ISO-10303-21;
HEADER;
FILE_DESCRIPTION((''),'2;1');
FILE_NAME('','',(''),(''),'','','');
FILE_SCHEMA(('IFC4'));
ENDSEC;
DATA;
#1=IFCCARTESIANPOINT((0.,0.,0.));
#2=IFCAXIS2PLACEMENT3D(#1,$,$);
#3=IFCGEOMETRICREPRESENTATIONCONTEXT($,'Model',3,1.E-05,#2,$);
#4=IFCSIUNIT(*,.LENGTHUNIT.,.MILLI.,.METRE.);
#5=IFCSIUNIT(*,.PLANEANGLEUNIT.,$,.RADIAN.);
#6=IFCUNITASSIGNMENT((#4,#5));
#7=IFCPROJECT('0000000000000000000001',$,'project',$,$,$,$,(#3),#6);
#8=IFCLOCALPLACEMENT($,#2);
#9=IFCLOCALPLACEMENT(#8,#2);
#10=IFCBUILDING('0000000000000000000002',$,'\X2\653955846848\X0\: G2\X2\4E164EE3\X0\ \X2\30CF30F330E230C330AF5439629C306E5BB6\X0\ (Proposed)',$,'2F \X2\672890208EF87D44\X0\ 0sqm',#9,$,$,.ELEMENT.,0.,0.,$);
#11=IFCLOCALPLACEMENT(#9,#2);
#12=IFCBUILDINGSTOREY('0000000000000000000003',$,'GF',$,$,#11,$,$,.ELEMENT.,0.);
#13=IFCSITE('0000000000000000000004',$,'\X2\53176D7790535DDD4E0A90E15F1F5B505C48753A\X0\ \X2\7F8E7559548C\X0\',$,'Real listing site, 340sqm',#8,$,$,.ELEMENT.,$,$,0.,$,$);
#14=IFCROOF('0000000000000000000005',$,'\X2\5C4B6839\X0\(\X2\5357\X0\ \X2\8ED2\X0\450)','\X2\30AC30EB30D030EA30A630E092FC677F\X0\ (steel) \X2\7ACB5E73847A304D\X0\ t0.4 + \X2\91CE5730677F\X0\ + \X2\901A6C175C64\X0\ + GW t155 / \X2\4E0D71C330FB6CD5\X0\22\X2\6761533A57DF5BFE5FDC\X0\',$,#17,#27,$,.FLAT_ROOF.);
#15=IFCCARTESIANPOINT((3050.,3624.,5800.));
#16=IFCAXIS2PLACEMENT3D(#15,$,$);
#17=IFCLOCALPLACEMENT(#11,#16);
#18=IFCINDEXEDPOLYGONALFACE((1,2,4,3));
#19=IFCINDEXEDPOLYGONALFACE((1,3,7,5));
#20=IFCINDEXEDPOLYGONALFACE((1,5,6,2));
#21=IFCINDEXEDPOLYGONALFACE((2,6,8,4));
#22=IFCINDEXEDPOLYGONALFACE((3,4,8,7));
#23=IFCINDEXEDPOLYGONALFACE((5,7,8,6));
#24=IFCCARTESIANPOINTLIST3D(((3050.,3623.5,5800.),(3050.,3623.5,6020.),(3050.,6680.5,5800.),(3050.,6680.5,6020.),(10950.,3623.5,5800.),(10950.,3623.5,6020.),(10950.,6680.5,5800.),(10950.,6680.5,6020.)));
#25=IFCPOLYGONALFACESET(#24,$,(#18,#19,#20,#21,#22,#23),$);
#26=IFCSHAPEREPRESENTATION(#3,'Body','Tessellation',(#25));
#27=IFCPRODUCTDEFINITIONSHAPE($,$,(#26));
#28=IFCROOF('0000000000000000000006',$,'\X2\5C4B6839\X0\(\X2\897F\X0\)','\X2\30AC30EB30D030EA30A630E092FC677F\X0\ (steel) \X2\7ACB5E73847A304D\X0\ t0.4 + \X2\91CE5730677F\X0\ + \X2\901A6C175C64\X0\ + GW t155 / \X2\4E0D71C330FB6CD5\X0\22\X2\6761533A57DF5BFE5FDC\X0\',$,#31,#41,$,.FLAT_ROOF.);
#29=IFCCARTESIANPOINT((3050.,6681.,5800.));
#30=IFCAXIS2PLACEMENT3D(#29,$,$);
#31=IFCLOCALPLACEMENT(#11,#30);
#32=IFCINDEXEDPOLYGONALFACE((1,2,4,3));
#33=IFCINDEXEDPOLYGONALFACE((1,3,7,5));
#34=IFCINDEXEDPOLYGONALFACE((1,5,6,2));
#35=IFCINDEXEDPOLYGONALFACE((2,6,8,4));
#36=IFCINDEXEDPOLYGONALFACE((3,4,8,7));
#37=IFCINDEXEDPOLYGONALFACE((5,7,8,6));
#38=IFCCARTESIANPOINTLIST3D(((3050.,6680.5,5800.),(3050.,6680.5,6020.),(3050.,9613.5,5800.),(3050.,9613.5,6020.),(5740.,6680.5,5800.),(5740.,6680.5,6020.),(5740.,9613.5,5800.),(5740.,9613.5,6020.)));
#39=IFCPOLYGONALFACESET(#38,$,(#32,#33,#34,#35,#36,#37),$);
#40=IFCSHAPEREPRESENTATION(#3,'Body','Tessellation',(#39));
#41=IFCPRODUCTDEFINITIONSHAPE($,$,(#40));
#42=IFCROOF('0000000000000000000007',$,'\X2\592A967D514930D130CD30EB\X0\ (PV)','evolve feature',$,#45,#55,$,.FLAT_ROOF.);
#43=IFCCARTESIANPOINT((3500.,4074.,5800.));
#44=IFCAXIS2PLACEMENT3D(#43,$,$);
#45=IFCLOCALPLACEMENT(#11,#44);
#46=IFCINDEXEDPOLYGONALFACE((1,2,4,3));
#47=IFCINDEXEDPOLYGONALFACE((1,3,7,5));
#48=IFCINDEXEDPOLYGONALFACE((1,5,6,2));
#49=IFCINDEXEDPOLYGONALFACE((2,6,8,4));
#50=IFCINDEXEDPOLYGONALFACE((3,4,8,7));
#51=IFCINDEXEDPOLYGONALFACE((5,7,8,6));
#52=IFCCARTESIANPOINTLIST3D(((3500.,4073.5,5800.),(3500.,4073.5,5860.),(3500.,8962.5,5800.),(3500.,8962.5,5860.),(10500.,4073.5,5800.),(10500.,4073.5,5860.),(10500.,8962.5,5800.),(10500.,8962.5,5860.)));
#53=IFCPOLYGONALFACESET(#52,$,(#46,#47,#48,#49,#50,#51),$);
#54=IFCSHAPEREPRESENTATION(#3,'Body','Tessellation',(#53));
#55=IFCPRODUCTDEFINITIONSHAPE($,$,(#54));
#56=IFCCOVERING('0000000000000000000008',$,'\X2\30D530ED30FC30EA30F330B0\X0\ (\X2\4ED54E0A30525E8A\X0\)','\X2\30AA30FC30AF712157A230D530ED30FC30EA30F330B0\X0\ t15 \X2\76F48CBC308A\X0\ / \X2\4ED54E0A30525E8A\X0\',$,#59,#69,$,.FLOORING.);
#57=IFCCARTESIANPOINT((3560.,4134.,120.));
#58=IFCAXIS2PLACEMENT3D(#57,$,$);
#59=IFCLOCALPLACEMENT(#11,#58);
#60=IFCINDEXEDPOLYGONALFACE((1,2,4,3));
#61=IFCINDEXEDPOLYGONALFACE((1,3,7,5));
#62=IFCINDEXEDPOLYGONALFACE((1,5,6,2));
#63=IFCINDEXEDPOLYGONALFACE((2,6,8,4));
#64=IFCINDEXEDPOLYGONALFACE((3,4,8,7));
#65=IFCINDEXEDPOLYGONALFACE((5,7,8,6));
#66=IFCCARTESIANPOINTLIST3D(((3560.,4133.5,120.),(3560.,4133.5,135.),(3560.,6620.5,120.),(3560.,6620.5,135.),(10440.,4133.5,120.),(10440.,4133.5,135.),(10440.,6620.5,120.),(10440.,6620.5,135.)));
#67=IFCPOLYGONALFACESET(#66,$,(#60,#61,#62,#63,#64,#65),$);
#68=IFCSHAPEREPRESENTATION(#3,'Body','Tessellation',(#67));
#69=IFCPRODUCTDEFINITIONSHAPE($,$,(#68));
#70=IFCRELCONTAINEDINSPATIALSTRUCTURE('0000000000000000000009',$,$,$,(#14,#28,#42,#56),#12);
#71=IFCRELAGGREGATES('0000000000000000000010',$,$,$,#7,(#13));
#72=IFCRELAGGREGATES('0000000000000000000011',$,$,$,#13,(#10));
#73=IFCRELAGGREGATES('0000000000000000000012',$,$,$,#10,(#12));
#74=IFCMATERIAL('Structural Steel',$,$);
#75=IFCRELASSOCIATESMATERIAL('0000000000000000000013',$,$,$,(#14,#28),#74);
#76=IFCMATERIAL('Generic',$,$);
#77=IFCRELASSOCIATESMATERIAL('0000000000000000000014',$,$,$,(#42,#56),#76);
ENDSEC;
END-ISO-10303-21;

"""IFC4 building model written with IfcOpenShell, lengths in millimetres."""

from ifc_helpers import new_model, si_unit, frame, frame_2d, origin, place, context, project, spatial, rectangle, extrude, material, element, save


model = new_model("IFC4")

# Units and contexts
model_context = context("Model", 3, precision=1e-05, world=origin())
ifc_project = project(units=[si_unit("LENGTHUNIT", "METRE", prefix="MILLI"), si_unit("PLANEANGLEUNIT", "RADIAN")], contexts=[model_context])

# Site, building, storey
site_placement = place(None, origin())
site = spatial("IfcSite", under=ifc_project, at=site_placement, Name="北海道川上郡弟子屈町 美留和", ObjectType="Real listing site, 340sqm", CompositionType="ELEMENT", RefElevation=0.0)
building_placement = place(site_placement, origin())
building = spatial("IfcBuilding", under=site, at=building_placement, Name="改善案: G2世代 ハンモック吹抜の家 (Proposed)", ObjectType="2F 木造軸組 0sqm", CompositionType="ELEMENT", ElevationOfRefHeight=0.0, ElevationOfTerrain=0.0)
storey_placement = place(building_placement, origin())
storey = spatial("IfcBuildingStorey", under=building, at=storey_placement, Name="GF", CompositionType="ELEMENT", Elevation=0.0)

# Shared definitions
ifc_material_1 = material(Name="Generic")

# Roofs
ifc_material_2 = material(Name="Structural Steel")
roof_1_placement = place(storey_placement, frame((3050.0, 3624.0, 5800.0)))
element("IfcRoof", 1, at=roof_1_placement, inside=storey, material=ifc_material_2, Name="屋根(南 軒450)", Description="ガルバリウム鋼板 (steel) 立平葺き t0.4 + 野地板 + 通気層 + GW t155 / 不燃・法22条区域対応", PredefinedType="FLAT_ROOF", context=model_context, shape_type="SweptSolid", body=[
    extrude(rectangle(XDim=7900.0, YDim=3057.0, at=frame_2d((3950.0, 1528.0))), frame((3050.0, 3624.0, 5800.0)), (0.0, 0.0, 1.0), 220.0),
])
roof_2_placement = place(storey_placement, frame((3050.0, 6681.0, 5800.0)))
element("IfcRoof", 2, at=roof_2_placement, inside=storey, material=ifc_material_2, Name="屋根(西)", Description="ガルバリウム鋼板 (steel) 立平葺き t0.4 + 野地板 + 通気層 + GW t155 / 不燃・法22条区域対応", PredefinedType="FLAT_ROOF", context=model_context, shape_type="SweptSolid", body=[
    extrude(rectangle(XDim=2690.0, YDim=2933.0, at=frame_2d((1345.0, 1466.0))), frame((3050.0, 6681.0, 5800.0)), (0.0, 0.0, 1.0), 220.0),
])
roof_3_placement = place(storey_placement, frame((3500.0, 4074.0, 5800.0)))
element("IfcRoof", 3, at=roof_3_placement, inside=storey, material=ifc_material_1, Name="太陽光パネル (PV)", Description="evolve feature", PredefinedType="FLAT_ROOF", context=model_context, shape_type="SweptSolid", body=[
    extrude(rectangle(XDim=7000.0, YDim=4889.0, at=frame_2d((3500.0, 2444.0))), frame((3500.0, 4074.0, 5800.0)), (0.0, 0.0, 1.0), 60.0),
])

# Covering
covering_placement = place(storey_placement, frame((3560.0, 4134.0, 120.0)))
element("IfcCovering", 4, at=covering_placement, inside=storey, material=ifc_material_1, Name="フローリング (仕上げ床)", Description="オーク無垢フローリング t15 直貼り / 仕上げ床", PredefinedType="FLOORING", context=model_context, shape_type="SweptSolid", body=[
    extrude(rectangle(XDim=6880.0, YDim=2487.0, at=frame_2d((3440.0, 1243.0))), frame((3560.0, 4134.0, 120.0)), (0.0, 0.0, 1.0), 15.0),
])

save(model, "model.ifc")
